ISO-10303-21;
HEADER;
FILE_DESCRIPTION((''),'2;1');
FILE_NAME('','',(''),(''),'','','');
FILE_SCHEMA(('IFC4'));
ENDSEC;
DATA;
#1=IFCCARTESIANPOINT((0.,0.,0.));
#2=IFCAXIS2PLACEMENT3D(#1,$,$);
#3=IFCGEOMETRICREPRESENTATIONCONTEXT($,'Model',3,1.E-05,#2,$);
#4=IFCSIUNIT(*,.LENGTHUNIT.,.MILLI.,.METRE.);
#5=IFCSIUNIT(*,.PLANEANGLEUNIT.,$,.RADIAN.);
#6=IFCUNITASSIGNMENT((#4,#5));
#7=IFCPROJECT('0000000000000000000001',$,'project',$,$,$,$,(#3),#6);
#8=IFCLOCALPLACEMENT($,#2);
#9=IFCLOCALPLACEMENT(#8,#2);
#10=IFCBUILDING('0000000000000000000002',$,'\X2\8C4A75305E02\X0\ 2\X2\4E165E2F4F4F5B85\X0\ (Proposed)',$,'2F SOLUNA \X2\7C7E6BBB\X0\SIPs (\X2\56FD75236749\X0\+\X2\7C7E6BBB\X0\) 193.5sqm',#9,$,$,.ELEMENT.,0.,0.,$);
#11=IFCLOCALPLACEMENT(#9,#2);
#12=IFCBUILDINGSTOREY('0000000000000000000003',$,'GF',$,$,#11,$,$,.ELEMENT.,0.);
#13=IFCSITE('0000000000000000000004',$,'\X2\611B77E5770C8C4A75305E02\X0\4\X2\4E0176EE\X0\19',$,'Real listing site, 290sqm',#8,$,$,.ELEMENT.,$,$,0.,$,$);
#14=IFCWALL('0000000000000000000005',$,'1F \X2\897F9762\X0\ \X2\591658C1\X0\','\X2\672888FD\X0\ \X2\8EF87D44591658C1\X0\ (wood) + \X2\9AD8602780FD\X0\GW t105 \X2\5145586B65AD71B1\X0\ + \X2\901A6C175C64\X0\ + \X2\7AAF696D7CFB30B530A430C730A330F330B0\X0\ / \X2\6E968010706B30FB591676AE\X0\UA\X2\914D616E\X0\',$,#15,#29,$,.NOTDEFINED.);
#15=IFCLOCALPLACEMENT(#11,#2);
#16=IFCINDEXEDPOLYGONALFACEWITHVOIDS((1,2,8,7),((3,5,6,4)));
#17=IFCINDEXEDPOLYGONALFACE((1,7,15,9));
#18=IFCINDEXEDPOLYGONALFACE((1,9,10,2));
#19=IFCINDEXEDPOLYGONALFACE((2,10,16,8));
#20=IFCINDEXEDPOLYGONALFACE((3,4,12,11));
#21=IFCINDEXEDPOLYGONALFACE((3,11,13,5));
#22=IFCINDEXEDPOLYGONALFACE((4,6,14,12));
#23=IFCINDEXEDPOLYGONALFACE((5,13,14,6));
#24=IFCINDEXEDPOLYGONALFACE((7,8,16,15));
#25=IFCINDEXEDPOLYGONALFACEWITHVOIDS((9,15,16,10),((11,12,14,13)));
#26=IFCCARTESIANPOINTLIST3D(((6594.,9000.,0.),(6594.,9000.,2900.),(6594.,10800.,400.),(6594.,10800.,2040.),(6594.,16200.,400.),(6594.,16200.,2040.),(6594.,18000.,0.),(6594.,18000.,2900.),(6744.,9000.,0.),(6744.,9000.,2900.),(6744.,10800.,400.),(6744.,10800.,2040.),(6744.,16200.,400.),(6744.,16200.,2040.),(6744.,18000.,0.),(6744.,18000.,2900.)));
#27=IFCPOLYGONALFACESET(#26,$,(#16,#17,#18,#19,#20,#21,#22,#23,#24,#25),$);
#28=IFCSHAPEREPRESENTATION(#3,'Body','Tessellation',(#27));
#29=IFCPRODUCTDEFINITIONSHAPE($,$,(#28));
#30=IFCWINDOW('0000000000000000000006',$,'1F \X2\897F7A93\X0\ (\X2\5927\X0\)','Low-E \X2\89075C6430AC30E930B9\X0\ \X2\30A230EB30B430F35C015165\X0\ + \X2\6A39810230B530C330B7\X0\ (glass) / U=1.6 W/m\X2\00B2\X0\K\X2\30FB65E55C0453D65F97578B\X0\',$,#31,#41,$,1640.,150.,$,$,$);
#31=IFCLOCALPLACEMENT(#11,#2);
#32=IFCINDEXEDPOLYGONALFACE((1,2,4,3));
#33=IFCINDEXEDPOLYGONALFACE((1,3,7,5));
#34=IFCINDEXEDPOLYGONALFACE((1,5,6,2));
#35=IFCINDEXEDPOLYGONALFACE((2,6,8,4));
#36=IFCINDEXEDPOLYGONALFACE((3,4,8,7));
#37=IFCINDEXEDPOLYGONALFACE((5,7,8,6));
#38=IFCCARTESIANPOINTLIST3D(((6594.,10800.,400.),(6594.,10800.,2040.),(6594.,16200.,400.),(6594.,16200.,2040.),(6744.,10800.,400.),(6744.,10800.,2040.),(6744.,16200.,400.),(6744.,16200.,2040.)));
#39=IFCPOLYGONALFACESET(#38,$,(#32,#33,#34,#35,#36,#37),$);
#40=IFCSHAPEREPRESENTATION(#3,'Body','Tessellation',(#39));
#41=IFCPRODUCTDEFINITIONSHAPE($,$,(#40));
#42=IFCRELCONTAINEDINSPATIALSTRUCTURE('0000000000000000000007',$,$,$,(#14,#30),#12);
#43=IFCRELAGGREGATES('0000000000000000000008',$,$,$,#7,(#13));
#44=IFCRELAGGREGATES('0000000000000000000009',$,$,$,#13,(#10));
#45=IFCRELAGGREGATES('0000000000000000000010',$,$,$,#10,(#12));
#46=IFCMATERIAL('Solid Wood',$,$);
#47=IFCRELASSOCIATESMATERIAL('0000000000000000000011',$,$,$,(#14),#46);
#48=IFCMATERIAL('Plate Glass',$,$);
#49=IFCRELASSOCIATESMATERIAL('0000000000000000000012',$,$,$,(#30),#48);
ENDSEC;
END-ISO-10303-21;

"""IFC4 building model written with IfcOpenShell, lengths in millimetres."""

from ifc_helpers import new_model, si_unit, frame, frame_2d, origin, place, context, project, spatial, rectangle, extrude, material, element, fill, save


model = new_model("IFC4")

# Units and contexts
model_context = context("Model", 3, precision=1e-05, world=origin())
ifc_project = project(units=[si_unit("LENGTHUNIT", "METRE", prefix="MILLI"), si_unit("PLANEANGLEUNIT", "RADIAN")], contexts=[model_context])

# Site, building, storey
site_placement = place(None, origin())
site = spatial("IfcSite", under=ifc_project, at=site_placement, Name="愛知県豊田市4丁目19", ObjectType="Real listing site, 290sqm", CompositionType="ELEMENT", RefElevation=0.0)
building_placement = place(site_placement, origin())
building = spatial("IfcBuilding", under=site, at=building_placement, Name="豊田市 2世帯住宅 (Proposed)", ObjectType="2F SOLUNA 籾殻SIPs (国産杉+籾殻) 193.5sqm", CompositionType="ELEMENT", ElevationOfRefHeight=0.0, ElevationOfTerrain=0.0)
storey_placement = place(building_placement, origin())
storey = spatial("IfcBuildingStorey", under=building, at=storey_placement, Name="GF", CompositionType="ELEMENT", Elevation=0.0)

# Shared definitions
ifc_material_1 = material(Name="Solid Wood")

# Shared definitions
ifc_material_2 = material(Name="Plate Glass")

# Wall, opening, window
wall_1_placement = place(storey_placement, frame((3297.0, 4500.0, 0.0)))
wall_1 = element("IfcWall", 1, at=wall_1_placement, inside=storey, material=ifc_material_1, Name="1F 西面 外壁", Description="木製 軸組外壁 (wood) + 高性能GW t105 充填断熱 + 通気層 + 窯業系サイディング / 準耐火・外皮UA配慮", PredefinedType="NOTDEFINED", context=model_context, shape_type="SweptSolid", body=[
    extrude(rectangle(XDim=150.0, YDim=9000.0, at=frame_2d((75.0, 4500.0))), frame((3297.0, 4500.0, 0.0)), (0.0, 0.0, 1.0), 2900.0),
])
opening_1_placement = place(storey_placement, frame((3297.0, 5400.0, 200.0)))
opening_1 = element("IfcOpeningElement", 2, at=opening_1_placement, cuts=wall_1, PredefinedType="NOTDEFINED", context=model_context, shape_type="SweptSolid", body=[
    extrude(rectangle(XDim=150.0, YDim=5400.0, at=frame_2d((75.0, 2700.0))), frame((3297.0, 5400.0, 200.0)), (0.0, 0.0, 1.0), 1640.0),
])
window_1_placement = place(storey_placement, frame((3297.0, 5400.0, 200.0)))
window_1 = element("IfcWindow", 3, at=window_1_placement, inside=storey, material=ifc_material_2, Name="1F 西窓 (大)", Description="Low-E 複層ガラス アルゴン封入 + 樹脂サッシ (glass) / U=1.6 W/m²K・日射取得型", OverallHeight=1640.0, OverallWidth=150.0, context=model_context, shape_type="SweptSolid", body=[
    extrude(rectangle(XDim=150.0, YDim=5400.0, at=frame_2d((75.0, 2700.0))), frame((3297.0, 5400.0, 200.0)), (0.0, 0.0, 1.0), 1640.0),
])
fill(opening_1, window_1)

save(model, "model.ifc")
